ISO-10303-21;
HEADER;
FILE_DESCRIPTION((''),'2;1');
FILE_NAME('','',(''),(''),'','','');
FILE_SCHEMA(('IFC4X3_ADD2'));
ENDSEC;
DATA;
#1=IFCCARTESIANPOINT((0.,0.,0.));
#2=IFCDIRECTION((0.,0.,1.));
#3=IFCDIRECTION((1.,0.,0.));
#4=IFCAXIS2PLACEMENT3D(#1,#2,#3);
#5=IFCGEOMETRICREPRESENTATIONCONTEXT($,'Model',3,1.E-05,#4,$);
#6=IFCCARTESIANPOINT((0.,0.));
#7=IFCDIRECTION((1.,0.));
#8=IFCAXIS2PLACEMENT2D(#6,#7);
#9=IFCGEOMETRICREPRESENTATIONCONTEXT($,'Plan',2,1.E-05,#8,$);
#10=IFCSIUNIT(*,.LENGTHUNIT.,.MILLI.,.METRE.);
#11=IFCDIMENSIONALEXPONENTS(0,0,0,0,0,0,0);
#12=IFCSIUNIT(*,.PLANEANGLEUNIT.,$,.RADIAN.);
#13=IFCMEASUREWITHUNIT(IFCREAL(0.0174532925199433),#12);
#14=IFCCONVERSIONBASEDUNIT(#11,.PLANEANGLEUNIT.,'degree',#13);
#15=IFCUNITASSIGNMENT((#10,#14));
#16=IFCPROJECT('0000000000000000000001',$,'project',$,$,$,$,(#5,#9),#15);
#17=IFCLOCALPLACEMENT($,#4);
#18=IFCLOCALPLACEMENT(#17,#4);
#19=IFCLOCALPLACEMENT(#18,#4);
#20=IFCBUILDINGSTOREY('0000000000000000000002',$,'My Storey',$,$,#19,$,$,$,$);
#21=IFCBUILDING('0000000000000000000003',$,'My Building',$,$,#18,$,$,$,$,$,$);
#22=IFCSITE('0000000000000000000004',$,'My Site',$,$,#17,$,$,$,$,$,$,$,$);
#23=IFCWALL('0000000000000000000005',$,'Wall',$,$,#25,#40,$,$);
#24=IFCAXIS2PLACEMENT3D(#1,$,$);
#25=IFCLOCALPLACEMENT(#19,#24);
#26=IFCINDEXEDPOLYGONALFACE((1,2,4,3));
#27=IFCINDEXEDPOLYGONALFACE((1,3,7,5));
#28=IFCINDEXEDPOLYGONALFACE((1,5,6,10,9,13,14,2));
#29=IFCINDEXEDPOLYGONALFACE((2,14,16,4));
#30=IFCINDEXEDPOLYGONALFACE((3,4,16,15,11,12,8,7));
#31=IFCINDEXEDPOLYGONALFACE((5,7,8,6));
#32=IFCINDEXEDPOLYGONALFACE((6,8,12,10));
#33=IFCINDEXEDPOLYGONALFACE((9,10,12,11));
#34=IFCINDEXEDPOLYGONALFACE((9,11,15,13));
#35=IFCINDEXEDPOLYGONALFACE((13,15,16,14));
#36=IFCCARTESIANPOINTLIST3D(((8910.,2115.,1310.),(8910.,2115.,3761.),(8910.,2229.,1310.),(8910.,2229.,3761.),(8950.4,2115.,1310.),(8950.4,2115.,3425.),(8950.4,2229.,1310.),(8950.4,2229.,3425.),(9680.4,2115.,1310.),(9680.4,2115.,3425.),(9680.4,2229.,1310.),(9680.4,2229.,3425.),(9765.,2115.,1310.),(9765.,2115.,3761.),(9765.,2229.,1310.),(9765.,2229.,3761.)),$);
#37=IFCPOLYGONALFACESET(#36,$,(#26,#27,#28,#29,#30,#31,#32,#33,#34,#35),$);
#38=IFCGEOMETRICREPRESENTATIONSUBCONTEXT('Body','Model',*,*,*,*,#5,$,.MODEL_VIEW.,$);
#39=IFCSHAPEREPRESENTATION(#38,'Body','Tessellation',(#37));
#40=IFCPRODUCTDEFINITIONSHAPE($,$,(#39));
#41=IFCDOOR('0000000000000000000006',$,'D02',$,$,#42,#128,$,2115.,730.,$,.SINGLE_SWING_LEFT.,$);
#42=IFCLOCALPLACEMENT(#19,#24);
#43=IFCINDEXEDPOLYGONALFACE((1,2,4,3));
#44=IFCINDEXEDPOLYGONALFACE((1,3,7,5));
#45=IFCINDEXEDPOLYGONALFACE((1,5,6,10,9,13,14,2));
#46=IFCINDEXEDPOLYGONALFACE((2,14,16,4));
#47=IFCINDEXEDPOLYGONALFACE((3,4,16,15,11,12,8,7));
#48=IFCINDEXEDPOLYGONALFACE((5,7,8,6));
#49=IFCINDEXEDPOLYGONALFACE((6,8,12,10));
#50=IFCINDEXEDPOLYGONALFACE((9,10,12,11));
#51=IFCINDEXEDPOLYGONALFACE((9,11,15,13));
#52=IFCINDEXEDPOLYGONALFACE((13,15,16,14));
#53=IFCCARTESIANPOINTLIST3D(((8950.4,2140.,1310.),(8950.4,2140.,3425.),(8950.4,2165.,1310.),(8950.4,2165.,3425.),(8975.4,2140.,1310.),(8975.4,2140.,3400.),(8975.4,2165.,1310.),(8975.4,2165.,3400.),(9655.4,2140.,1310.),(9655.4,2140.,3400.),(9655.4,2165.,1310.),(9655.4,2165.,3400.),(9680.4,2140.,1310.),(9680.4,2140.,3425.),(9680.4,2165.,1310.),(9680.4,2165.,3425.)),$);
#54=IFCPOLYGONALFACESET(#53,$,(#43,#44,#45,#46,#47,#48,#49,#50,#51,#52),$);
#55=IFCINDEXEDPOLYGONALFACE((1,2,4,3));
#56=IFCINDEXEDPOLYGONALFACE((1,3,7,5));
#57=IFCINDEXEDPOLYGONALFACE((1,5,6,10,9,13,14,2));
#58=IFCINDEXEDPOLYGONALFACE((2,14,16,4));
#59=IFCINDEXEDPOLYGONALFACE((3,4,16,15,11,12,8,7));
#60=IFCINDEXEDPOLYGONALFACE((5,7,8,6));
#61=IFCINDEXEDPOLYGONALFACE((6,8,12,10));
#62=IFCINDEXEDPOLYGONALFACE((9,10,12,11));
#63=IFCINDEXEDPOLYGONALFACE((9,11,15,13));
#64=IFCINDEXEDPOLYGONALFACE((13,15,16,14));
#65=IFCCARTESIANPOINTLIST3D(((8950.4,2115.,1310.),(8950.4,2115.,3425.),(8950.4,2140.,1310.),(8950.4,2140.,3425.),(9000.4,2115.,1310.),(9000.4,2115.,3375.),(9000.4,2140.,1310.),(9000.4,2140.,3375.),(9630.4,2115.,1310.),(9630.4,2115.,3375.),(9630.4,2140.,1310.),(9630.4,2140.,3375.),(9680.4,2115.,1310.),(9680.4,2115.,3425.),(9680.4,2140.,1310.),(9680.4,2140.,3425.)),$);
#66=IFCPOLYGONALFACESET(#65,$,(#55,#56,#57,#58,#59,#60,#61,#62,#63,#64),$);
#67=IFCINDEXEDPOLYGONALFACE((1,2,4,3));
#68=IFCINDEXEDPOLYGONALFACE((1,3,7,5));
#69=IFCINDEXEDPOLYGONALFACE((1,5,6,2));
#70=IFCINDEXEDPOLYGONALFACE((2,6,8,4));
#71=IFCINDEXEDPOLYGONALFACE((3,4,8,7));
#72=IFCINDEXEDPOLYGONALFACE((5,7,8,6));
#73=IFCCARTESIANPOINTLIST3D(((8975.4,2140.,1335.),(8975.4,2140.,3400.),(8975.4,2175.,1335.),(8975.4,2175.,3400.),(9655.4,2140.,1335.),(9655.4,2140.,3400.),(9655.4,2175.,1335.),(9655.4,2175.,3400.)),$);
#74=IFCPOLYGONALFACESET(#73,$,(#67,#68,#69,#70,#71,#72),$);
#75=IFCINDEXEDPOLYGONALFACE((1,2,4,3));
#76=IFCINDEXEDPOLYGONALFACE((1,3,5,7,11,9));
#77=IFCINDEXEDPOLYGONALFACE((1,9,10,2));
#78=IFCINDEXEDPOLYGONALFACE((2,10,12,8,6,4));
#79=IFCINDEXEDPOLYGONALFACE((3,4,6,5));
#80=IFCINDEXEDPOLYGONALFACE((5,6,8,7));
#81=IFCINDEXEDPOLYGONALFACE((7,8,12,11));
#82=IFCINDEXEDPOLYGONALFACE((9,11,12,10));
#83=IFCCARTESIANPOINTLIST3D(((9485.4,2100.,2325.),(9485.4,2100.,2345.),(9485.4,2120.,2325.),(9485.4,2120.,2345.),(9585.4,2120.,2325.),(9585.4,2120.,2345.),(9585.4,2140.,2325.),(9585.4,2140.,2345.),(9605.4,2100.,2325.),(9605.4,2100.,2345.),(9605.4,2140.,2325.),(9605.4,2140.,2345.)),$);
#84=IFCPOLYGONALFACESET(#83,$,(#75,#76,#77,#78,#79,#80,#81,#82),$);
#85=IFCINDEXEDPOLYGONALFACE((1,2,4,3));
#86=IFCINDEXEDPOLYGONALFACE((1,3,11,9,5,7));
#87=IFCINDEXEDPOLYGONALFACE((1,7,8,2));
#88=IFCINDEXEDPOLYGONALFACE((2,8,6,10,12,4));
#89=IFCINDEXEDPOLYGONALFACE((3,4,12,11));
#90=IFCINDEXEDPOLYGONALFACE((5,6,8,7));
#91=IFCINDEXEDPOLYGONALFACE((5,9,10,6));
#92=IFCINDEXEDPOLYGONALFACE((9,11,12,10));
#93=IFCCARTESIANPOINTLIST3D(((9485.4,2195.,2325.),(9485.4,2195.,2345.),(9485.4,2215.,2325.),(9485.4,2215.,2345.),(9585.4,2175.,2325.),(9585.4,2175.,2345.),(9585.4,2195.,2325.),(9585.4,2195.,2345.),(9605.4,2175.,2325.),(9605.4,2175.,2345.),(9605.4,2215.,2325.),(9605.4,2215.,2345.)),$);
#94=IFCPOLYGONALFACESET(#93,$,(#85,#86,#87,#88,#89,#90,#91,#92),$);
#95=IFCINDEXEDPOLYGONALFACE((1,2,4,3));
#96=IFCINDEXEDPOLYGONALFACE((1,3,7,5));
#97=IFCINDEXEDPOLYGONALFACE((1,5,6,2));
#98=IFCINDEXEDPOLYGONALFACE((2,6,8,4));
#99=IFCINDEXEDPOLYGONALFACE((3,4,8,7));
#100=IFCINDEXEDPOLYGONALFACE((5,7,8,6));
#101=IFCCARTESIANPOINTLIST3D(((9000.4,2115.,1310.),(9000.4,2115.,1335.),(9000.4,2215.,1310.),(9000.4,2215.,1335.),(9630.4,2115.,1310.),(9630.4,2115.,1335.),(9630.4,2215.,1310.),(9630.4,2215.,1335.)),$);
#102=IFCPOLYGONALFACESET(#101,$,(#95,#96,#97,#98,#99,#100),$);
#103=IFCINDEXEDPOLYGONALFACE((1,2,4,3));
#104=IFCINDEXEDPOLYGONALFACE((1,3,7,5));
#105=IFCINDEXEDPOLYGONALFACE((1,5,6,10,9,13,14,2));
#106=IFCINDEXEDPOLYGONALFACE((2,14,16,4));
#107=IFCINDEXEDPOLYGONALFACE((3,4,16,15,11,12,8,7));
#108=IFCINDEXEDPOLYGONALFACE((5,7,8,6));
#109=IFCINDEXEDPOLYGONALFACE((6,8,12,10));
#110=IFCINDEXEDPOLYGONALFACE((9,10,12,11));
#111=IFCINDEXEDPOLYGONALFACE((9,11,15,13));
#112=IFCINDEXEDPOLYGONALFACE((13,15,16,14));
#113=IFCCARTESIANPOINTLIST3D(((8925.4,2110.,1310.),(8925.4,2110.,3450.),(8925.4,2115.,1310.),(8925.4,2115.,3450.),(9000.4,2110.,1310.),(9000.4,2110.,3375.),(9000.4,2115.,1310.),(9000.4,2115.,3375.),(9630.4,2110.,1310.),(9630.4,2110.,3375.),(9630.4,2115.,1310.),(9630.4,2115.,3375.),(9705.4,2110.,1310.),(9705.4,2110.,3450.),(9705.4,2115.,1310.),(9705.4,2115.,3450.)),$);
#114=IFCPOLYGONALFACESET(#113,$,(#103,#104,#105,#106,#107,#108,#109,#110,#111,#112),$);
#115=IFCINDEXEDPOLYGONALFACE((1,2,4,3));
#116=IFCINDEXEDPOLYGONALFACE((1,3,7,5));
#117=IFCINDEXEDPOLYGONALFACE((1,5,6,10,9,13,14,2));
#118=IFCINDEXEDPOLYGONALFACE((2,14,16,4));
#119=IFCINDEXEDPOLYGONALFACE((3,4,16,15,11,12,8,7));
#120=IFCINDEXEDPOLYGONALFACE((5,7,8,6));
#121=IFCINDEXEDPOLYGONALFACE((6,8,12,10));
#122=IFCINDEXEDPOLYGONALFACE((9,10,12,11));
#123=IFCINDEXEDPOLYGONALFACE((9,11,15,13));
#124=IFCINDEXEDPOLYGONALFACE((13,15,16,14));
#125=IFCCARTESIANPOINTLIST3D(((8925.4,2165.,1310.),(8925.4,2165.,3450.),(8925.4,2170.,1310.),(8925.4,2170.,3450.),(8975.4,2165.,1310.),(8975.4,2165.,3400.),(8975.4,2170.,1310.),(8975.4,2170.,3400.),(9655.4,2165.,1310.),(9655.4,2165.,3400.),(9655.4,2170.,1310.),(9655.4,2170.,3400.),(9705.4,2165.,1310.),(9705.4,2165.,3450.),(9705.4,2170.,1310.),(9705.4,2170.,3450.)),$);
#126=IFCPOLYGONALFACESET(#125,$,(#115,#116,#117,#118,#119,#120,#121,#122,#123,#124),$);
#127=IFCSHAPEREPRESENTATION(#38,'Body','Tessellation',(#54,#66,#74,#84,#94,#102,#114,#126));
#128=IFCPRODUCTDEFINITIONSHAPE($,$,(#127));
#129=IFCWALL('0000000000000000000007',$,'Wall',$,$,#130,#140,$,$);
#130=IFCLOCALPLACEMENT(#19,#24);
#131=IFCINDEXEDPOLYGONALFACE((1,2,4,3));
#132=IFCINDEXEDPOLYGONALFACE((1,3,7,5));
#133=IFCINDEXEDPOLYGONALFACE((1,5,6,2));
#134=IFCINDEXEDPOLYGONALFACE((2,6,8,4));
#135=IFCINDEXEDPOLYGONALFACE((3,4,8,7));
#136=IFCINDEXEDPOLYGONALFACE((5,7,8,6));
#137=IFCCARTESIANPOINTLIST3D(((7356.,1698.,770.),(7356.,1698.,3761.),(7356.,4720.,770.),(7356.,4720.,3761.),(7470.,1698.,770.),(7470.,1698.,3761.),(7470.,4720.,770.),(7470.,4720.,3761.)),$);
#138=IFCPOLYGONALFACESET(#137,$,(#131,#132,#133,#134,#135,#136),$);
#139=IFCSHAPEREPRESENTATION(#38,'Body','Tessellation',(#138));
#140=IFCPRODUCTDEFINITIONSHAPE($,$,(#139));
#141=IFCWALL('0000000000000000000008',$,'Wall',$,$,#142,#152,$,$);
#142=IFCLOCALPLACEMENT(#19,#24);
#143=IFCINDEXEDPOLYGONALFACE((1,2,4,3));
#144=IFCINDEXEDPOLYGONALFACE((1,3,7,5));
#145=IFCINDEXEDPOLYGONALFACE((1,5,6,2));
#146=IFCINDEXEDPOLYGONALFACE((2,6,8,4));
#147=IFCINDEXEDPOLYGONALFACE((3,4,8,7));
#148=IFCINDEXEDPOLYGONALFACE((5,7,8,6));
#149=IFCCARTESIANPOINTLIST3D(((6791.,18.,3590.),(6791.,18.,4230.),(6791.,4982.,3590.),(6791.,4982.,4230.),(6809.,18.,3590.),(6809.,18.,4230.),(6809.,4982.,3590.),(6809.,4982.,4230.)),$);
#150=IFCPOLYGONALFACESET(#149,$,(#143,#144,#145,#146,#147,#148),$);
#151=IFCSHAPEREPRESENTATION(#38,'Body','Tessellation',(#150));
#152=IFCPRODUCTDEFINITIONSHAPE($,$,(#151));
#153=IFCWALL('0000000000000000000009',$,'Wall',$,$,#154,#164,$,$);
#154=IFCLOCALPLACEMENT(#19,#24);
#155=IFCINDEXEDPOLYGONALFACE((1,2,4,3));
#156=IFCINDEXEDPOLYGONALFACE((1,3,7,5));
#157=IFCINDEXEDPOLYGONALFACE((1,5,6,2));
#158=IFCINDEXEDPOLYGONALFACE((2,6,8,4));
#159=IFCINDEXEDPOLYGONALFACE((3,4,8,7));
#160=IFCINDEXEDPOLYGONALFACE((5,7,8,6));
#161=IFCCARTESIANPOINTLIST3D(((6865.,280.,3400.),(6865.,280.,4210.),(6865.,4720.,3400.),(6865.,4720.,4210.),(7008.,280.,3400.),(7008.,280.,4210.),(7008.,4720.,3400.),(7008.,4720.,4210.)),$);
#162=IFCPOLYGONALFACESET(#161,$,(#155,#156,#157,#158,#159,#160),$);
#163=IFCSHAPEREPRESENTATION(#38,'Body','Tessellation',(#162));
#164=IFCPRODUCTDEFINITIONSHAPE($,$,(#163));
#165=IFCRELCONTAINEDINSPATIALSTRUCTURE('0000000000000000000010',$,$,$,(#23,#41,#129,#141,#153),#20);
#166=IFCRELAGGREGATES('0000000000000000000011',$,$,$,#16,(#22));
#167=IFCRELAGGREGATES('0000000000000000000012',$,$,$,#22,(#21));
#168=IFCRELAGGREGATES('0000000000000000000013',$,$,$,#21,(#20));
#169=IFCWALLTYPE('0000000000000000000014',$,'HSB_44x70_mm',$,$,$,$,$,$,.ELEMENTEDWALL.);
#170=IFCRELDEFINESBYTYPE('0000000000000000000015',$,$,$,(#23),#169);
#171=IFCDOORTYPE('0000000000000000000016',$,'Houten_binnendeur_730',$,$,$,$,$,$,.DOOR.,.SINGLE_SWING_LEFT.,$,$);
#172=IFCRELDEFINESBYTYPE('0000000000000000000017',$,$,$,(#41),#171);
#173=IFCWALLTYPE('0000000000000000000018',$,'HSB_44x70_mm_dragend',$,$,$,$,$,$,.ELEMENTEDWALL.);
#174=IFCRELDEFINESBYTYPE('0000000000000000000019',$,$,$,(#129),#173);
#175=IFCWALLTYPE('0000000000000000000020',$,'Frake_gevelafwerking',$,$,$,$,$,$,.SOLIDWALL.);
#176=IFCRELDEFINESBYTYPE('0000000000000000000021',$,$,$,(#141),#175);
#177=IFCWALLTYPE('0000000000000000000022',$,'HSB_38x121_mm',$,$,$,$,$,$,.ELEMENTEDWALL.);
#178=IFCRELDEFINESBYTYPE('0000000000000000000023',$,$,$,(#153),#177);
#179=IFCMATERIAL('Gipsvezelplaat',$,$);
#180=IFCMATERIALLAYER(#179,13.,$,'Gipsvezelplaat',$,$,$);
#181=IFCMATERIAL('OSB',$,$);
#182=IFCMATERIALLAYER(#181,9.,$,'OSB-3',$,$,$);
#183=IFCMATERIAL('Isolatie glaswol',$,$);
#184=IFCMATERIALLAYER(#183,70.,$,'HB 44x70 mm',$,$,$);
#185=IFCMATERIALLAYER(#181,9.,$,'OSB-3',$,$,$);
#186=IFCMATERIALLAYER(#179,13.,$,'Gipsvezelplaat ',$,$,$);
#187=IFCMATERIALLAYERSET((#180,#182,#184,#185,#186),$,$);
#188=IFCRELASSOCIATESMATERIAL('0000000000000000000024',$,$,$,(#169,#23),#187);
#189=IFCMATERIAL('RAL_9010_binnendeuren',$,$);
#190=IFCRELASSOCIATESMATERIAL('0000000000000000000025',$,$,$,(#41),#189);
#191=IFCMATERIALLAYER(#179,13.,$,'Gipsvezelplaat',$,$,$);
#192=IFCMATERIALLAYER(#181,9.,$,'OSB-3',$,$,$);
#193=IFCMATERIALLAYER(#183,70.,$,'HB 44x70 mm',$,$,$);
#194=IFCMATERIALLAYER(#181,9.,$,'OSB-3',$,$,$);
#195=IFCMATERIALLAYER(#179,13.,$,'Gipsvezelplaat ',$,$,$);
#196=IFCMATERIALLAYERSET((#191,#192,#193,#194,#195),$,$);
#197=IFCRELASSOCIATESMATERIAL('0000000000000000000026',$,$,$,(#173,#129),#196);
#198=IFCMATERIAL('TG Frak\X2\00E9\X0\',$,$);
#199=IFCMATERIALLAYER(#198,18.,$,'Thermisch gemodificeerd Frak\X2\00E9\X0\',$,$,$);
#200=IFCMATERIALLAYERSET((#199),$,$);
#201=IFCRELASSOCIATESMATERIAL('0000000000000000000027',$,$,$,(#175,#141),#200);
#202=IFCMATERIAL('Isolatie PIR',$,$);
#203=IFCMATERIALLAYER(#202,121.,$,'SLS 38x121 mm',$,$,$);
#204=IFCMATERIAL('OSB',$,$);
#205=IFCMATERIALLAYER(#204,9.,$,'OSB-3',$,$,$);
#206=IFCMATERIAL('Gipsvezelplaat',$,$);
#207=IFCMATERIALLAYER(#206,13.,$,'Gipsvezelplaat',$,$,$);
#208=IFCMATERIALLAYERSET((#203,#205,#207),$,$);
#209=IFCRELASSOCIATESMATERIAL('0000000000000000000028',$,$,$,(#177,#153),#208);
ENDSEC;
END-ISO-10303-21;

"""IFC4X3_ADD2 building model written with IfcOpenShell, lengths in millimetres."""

from ifc_helpers import new_model, entity, si_unit, converted_unit, frame, origin_with_axes, origin_2d_with_axis, place, context, subcontext, project, spatial, line, indexed_curve, outline, extrude, shape, source, transform, mapped, material, layer, layer_set, layer_usage, type_object, type_shapes, element, fill, save


model = new_model("IFC4X3_ADD2")

# Units and contexts
model_context = context("Model", 3, precision=1e-05, world=origin_with_axes())
plan_context = context("Plan", 2, precision=1e-05, world=origin_2d_with_axis())
body_context_1 = subcontext(model_context, "Body", "Model", "MODEL_VIEW")
body_context_2 = subcontext(plan_context, "Body", "Plan", "PLAN_VIEW")
ifc_project = project(units=[si_unit("LENGTHUNIT", "METRE", prefix="MILLI"), converted_unit("PLANEANGLEUNIT", "degree", entity("IfcReal", 0.0174532925199433), si_unit("PLANEANGLEUNIT", "RADIAN"), dimensions=[0, 0, 0, 0, 0, 0, 0])], contexts=[model_context, plan_context])

# Site, building, storey
site_placement = place(None, origin_with_axes())
site = spatial("IfcSite", under=ifc_project, at=site_placement, Name="My Site")
building_placement = place(site_placement, origin_with_axes())
building = spatial("IfcBuilding", under=site, at=building_placement, Name="My Building")
storey_placement = place(building_placement, origin_with_axes())
storey = spatial("IfcBuildingStorey", under=building, at=storey_placement, Name="My Storey")

# Shared definitions
ifc_material_1 = material(Name="Isolatie glaswol")
ifc_material_2 = material(Name="Gipsvezelplaat")

# Shared definitions
ifc_material_3 = material(Name="OSB")

# Shared definitions
ifc_layer_1 = layer(ifc_material_2, 13.0, Name="Gipsvezelplaat")
ifc_layer_2 = layer(ifc_material_3, 9.0, Name="OSB-3")
ifc_layer_3 = layer(ifc_material_1, 70.0, Name="HB 44x70 mm")
ifc_layer_4 = layer(ifc_material_3, 9.0, Name="OSB-3")
ifc_layer_5 = layer(ifc_material_2, 13.0, Name="Gipsvezelplaat ")
ifc_layer_set_1 = layer_set([ifc_layer_1, ifc_layer_2, ifc_layer_3, ifc_layer_4, ifc_layer_5])
wall_type_1 = type_object("IfcWallType", Name="HSB_44x70_mm", PredefinedType="ELEMENTEDWALL", material=ifc_layer_set_1)

# Shared definitions
ifc_material_4 = material(Name="RAL_9010_binnendeuren")

# Wall, opening, door
ifc_layer_usage_1 = layer_usage(ifc_layer_set_1, "AXIS2", "POSITIVE", 0.0)
wall_1_placement = place(storey_placement, frame((8910.0, 2115.0, 1310.0), z_axis=(0.0, 0.0, 1.0), x_axis=(1.0, 0.0, 0.0)))
wall_1 = element("IfcWall", 1, at=wall_1_placement, inside=storey, type_object=wall_type_1, material=ifc_layer_usage_1, Name="Wall", context=body_context_1, shape_type="SweptSolid", body=[
    extrude(outline(indexed_curve([(0.0, 0.0), (0.0, 114.0), (855.0, 114.0), (855.0, 0.0), (0.0, 0.0)], self_intersect=False)), origin_with_axes(), (0.0, 0.0, 1.0), 2451.0),
])
shared_shape_1 = source(origin_with_axes(), body_context_1, "Body", "SweptSolid", [
    extrude(outline(indexed_curve([(0.0, 0.0), (730.0, 0.0), (730.0, 2115.0), (0.0, 2115.0)], segments=[line(1, 2, 3, 4, 1)])), frame((0.0, -600.0, 0.0), z_axis=(0.0, -1.0, 0.0), x_axis=(1.0, 0.0, 0.0)), (0.0, 0.0, -1.0), 1200.0),
])
opening_1_placement = place(wall_1_placement, frame((40.4, 0.0, 0.0), z_axis=(0.0, 0.0, 1.0), x_axis=(1.0, 0.0, 0.0)))
opening_1 = element("IfcOpeningElement", 2, at=opening_1_placement, cuts=wall_1, PredefinedType="OPENING", context=body_context_1, shape_type="MappedRepresentation", body=[
    mapped(shared_shape_1, transform((0.0, 0.0, 0.0), x_axis=(1.0, 0.0, 0.0), y_axis=(0.0, 1.0, 0.0), z_axis=(0.0, 0.0, 1.0), scale=1.0)),
])
door_type_1 = type_object("IfcDoorType", Name="Houten_binnendeur_730", OperationType="SINGLE_SWING_LEFT", PredefinedType="DOOR")
shared_shape_2 = source(origin_with_axes(), body_context_1, "Body", "SweptSolid", [
    extrude(outline(indexed_curve([(0.0, 0.0), (0.0, 2115.0), (730.0, 2115.0), (730.0, 0.0), (705.0, 0.0), (705.0, 2090.0), (25.0, 2090.0), (25.0, 0.0)], segments=[line(1, 2, 3, 4, 5, 6, 7, 8, 1)])), frame((0.0, 25.0, 0.0), z_axis=(0.0, -1.0, 0.0), x_axis=(1.0, 0.0, 0.0)), (0.0, 0.0, -1.0), 25.0),
    extrude(outline(indexed_curve([(0.0, 0.0), (0.0, 2115.0), (730.0, 2115.0), (730.0, 0.0), (680.0, 0.0), (680.0, 2065.0), (50.0, 2065.0), (50.0, 0.0)], segments=[line(1, 2, 3, 4, 5, 6, 7, 8, 1)])), frame((0.0, 0.0, 0.0), z_axis=(0.0, -1.0, 0.0), x_axis=(1.0, 0.0, 0.0)), (0.0, 0.0, -1.0), 25.0),
    extrude(outline(indexed_curve([(0.0, 0.0), (680.0, 0.0), (680.0, 35.0), (0.0, 35.0)], segments=[line(1, 2, 3, 4, 1)])), frame((25.0, 25.0, 25.0), z_axis=(0.0, 0.0, 1.0), x_axis=(1.0, 0.0, 0.0)), (0.0, 0.0, 1.0), 2065.0),
    extrude(outline(indexed_curve([(0.0, 0.0), (0.0, -40.0), (-120.0, -40.0), (-120.0, -20.0), (-20.0, -20.0), (-20.0, 0.0)], segments=[line(1, 2, 3, 4, 5, 6, 1)])), frame((655.0, 25.0, 1015.0), z_axis=(0.0, 0.0, 1.0), x_axis=(1.0, 0.0, 0.0)), (0.0, 0.0, 1.0), 20.0),
    extrude(outline(indexed_curve([(0.0, 0.0), (0.0, 40.0), (-120.0, 40.0), (-120.0, 20.0), (-20.0, 20.0), (-20.0, 0.0)], segments=[line(1, 2, 3, 4, 5, 6, 1)])), frame((655.0, 60.0, 1015.0), z_axis=(0.0, 0.0, 1.0), x_axis=(1.0, 0.0, 0.0)), (0.0, 0.0, 1.0), 20.0),
    extrude(outline(indexed_curve([(0.0, 0.0), (630.0, 0.0), (630.0, 100.0), (0.0, 100.0)], segments=[line(1, 2, 3, 4, 1)])), frame((50.0, 0.0, 0.0), z_axis=(0.0, 0.0, 1.0), x_axis=(1.0, 0.0, 0.0)), (0.0, 0.0, 1.0), 25.0),
    extrude(outline(indexed_curve([(0.0, 0.0), (0.0, 2140.0), (780.0, 2140.0), (780.0, 0.0), (705.0, 0.0), (705.0, 2065.0), (75.0, 2065.0), (75.0, 0.0)], segments=[line(1, 2, 3, 4, 5, 6, 7, 8, 1)])), frame((-25.0, -5.0, 0.0), z_axis=(0.0, -1.0, 0.0), x_axis=(1.0, 0.0, 0.0)), (0.0, 0.0, -1.0), 5.0),
    extrude(outline(indexed_curve([(0.0, 0.0), (0.0, 2140.0), (780.0, 2140.0), (780.0, 0.0), (730.0, 0.0), (730.0, 2090.0), (50.0, 2090.0), (50.0, 0.0)], segments=[line(1, 2, 3, 4, 5, 6, 7, 8, 1)])), frame((-25.0, 50.0, 0.0), z_axis=(0.0, -1.0, 0.0), x_axis=(1.0, 0.0, 0.0)), (0.0, 0.0, -1.0), 5.0),
])
shared_shape_3 = source(origin_with_axes(), body_context_2, "Body", "Curve2D", [
    entity("IfcIndexedPolyCurve", entity("IfcCartesianPointList2D", [[0.0, 0.0], [0.0, 50.0], [25.0, 50.0], [25.0, 25.0], [50.0, 25.0], [50.0, 0.0]]), [entity("IfcLineIndex", [1, 2, 3, 4, 5, 6, 1])]),
    entity("IfcIndexedPolyCurve", entity("IfcCartesianPointList2D", [[730.0, 0.0], [730.0, 50.0], [705.0, 50.0], [705.0, 25.0], [680.0, 25.0], [680.0, 0.0]]), [entity("IfcLineIndex", [1, 2, 3, 4, 5, 6, 1])]),
    entity("IfcTrimmedCurve", entity("IfcEllipse", entity("IfcAxis2Placement2D", entity("IfcCartesianPoint", [60.0, 50.0]), entity("IfcDirection", [1.0, 0.0])), 645.0, 680.0), [entity("IfcCartesianPoint", [705.0, 50.0])], [entity("IfcCartesianPoint", [60.0, 730.0])], True, "CARTESIAN"),
    entity("IfcIndexedPolyCurve", entity("IfcCartesianPointList2D", [[25.0, 50.0], [60.0, 50.0], [60.0, 730.0], [25.0, 730.0]]), [entity("IfcLineIndex", [1, 2, 3, 4, 1])]),
])
type_shapes(door_type_1, [shared_shape_2, shared_shape_3])
door_1_placement = place(opening_1_placement, origin_with_axes())
door_1 = element("IfcDoor", 3, at=door_1_placement, inside=storey, type_object=door_type_1, material=ifc_material_4, Name="D02", OperationType="SINGLE_SWING_LEFT", OverallHeight=2115.0, OverallWidth=730.0, shapes=[
    shape(body_context_1, "Body", "MappedRepresentation", [mapped(shared_shape_2, transform((0.0, 0.0, 0.0), x_axis=(1.0, 0.0, 0.0), y_axis=(0.0, 1.0, 0.0), z_axis=(0.0, 0.0, 1.0), scale=1.0))]),
    shape(body_context_2, "Body", "MappedRepresentation", [mapped(shared_shape_3, transform((0.0, 0.0, 0.0), x_axis=(1.0, 0.0, 0.0), y_axis=(0.0, 1.0, 0.0), z_axis=(0.0, 0.0, 1.0), scale=1.0))]),
])
fill(opening_1, door_1)

# Walls
ifc_layer_6 = layer(ifc_material_2, 13.0, Name="Gipsvezelplaat")
ifc_layer_7 = layer(ifc_material_3, 9.0, Name="OSB-3")
ifc_layer_8 = layer(ifc_material_1, 70.0, Name="HB 44x70 mm")
ifc_layer_9 = layer(ifc_material_3, 9.0, Name="OSB-3")
ifc_layer_10 = layer(ifc_material_2, 13.0, Name="Gipsvezelplaat ")
ifc_layer_set_2 = layer_set([ifc_layer_6, ifc_layer_7, ifc_layer_8, ifc_layer_9, ifc_layer_10])
ifc_layer_usage_2 = layer_usage(ifc_layer_set_2, "AXIS2", "POSITIVE", 0.0)
wall_type_2 = type_object("IfcWallType", Name="HSB_44x70_mm_dragend", PredefinedType="ELEMENTEDWALL", material=ifc_layer_set_2)
wall_2_placement = place(storey_placement, frame((7470.0, 1698.0, 770.0), z_axis=(0.0, 0.0, 1.0), x_axis=(0.0, 1.0, 0.0)))
element("IfcWall", 4, at=wall_2_placement, inside=storey, type_object=wall_type_2, material=ifc_layer_usage_2, Name="Wall", context=body_context_1, shape_type="SweptSolid", body=[
    extrude(outline(indexed_curve([(0.0, 0.0), (0.0, 114.0), (3022.0, 114.0), (3022.0, 0.0), (0.0, 0.0)], self_intersect=False)), origin_with_axes(), (0.0, 0.0, 1.0), 2991.0),
])
ifc_material_5 = material(Name="TG Fraké")
ifc_layer_11 = layer(ifc_material_5, 18.0, Name="Thermisch gemodificeerd Fraké")
ifc_layer_set_3 = layer_set([ifc_layer_11])
ifc_layer_usage_3 = layer_usage(ifc_layer_set_3, "AXIS2", "POSITIVE", 0.0)
wall_type_3 = type_object("IfcWallType", Name="Frake_gevelafwerking", PredefinedType="SOLIDWALL", material=ifc_layer_set_3)
wall_3_placement = place(storey_placement, frame((6809.0, 18.0, 3590.0), z_axis=(0.0, 0.0, 1.0), x_axis=(0.0, 1.0, 0.0)))
element("IfcWall", 5, at=wall_3_placement, inside=storey, type_object=wall_type_3, material=ifc_layer_usage_3, Name="Wall", context=body_context_1, shape_type="SweptSolid", body=[
    extrude(outline(indexed_curve([(0.0, 0.0), (0.0, 18.0), (4964.0, 18.0), (4964.0, 0.0), (0.0, 0.0)], self_intersect=False)), origin_with_axes(), (0.0, 0.0, 1.0), 640.0),
])
ifc_material_6 = material(Name="Isolatie PIR")
ifc_layer_12 = layer(ifc_material_6, 121.0, Name="SLS 38x121 mm")
ifc_material_7 = material(Name="OSB")
ifc_layer_13 = layer(ifc_material_7, 9.0, Name="OSB-3")
ifc_material_8 = material(Name="Gipsvezelplaat")
ifc_layer_14 = layer(ifc_material_8, 13.0, Name="Gipsvezelplaat")
ifc_layer_set_4 = layer_set([ifc_layer_12, ifc_layer_13, ifc_layer_14])
ifc_layer_usage_4 = layer_usage(ifc_layer_set_4, "AXIS2", "POSITIVE", 0.0)
wall_type_4 = type_object("IfcWallType", Name="HSB_38x121_mm", PredefinedType="ELEMENTEDWALL", material=ifc_layer_set_4)
wall_4_placement = place(storey_placement, frame((6865.0, 4720.0, 3400.0), z_axis=(0.0, 0.0, 1.0), x_axis=(0.0, -1.0, 0.0)))
element("IfcWall", 6, at=wall_4_placement, inside=storey, type_object=wall_type_4, material=ifc_layer_usage_4, Name="Wall", context=body_context_1, shape_type="SweptSolid", body=[
    extrude(outline(indexed_curve([(0.0, 0.0), (0.0, 143.0), (4440.0, 143.0), (4440.0, 0.0), (0.0, 0.0)], self_intersect=False)), origin_with_axes(), (0.0, 0.0, 1.0), 810.0),
])

save(model, "model.ifc")
